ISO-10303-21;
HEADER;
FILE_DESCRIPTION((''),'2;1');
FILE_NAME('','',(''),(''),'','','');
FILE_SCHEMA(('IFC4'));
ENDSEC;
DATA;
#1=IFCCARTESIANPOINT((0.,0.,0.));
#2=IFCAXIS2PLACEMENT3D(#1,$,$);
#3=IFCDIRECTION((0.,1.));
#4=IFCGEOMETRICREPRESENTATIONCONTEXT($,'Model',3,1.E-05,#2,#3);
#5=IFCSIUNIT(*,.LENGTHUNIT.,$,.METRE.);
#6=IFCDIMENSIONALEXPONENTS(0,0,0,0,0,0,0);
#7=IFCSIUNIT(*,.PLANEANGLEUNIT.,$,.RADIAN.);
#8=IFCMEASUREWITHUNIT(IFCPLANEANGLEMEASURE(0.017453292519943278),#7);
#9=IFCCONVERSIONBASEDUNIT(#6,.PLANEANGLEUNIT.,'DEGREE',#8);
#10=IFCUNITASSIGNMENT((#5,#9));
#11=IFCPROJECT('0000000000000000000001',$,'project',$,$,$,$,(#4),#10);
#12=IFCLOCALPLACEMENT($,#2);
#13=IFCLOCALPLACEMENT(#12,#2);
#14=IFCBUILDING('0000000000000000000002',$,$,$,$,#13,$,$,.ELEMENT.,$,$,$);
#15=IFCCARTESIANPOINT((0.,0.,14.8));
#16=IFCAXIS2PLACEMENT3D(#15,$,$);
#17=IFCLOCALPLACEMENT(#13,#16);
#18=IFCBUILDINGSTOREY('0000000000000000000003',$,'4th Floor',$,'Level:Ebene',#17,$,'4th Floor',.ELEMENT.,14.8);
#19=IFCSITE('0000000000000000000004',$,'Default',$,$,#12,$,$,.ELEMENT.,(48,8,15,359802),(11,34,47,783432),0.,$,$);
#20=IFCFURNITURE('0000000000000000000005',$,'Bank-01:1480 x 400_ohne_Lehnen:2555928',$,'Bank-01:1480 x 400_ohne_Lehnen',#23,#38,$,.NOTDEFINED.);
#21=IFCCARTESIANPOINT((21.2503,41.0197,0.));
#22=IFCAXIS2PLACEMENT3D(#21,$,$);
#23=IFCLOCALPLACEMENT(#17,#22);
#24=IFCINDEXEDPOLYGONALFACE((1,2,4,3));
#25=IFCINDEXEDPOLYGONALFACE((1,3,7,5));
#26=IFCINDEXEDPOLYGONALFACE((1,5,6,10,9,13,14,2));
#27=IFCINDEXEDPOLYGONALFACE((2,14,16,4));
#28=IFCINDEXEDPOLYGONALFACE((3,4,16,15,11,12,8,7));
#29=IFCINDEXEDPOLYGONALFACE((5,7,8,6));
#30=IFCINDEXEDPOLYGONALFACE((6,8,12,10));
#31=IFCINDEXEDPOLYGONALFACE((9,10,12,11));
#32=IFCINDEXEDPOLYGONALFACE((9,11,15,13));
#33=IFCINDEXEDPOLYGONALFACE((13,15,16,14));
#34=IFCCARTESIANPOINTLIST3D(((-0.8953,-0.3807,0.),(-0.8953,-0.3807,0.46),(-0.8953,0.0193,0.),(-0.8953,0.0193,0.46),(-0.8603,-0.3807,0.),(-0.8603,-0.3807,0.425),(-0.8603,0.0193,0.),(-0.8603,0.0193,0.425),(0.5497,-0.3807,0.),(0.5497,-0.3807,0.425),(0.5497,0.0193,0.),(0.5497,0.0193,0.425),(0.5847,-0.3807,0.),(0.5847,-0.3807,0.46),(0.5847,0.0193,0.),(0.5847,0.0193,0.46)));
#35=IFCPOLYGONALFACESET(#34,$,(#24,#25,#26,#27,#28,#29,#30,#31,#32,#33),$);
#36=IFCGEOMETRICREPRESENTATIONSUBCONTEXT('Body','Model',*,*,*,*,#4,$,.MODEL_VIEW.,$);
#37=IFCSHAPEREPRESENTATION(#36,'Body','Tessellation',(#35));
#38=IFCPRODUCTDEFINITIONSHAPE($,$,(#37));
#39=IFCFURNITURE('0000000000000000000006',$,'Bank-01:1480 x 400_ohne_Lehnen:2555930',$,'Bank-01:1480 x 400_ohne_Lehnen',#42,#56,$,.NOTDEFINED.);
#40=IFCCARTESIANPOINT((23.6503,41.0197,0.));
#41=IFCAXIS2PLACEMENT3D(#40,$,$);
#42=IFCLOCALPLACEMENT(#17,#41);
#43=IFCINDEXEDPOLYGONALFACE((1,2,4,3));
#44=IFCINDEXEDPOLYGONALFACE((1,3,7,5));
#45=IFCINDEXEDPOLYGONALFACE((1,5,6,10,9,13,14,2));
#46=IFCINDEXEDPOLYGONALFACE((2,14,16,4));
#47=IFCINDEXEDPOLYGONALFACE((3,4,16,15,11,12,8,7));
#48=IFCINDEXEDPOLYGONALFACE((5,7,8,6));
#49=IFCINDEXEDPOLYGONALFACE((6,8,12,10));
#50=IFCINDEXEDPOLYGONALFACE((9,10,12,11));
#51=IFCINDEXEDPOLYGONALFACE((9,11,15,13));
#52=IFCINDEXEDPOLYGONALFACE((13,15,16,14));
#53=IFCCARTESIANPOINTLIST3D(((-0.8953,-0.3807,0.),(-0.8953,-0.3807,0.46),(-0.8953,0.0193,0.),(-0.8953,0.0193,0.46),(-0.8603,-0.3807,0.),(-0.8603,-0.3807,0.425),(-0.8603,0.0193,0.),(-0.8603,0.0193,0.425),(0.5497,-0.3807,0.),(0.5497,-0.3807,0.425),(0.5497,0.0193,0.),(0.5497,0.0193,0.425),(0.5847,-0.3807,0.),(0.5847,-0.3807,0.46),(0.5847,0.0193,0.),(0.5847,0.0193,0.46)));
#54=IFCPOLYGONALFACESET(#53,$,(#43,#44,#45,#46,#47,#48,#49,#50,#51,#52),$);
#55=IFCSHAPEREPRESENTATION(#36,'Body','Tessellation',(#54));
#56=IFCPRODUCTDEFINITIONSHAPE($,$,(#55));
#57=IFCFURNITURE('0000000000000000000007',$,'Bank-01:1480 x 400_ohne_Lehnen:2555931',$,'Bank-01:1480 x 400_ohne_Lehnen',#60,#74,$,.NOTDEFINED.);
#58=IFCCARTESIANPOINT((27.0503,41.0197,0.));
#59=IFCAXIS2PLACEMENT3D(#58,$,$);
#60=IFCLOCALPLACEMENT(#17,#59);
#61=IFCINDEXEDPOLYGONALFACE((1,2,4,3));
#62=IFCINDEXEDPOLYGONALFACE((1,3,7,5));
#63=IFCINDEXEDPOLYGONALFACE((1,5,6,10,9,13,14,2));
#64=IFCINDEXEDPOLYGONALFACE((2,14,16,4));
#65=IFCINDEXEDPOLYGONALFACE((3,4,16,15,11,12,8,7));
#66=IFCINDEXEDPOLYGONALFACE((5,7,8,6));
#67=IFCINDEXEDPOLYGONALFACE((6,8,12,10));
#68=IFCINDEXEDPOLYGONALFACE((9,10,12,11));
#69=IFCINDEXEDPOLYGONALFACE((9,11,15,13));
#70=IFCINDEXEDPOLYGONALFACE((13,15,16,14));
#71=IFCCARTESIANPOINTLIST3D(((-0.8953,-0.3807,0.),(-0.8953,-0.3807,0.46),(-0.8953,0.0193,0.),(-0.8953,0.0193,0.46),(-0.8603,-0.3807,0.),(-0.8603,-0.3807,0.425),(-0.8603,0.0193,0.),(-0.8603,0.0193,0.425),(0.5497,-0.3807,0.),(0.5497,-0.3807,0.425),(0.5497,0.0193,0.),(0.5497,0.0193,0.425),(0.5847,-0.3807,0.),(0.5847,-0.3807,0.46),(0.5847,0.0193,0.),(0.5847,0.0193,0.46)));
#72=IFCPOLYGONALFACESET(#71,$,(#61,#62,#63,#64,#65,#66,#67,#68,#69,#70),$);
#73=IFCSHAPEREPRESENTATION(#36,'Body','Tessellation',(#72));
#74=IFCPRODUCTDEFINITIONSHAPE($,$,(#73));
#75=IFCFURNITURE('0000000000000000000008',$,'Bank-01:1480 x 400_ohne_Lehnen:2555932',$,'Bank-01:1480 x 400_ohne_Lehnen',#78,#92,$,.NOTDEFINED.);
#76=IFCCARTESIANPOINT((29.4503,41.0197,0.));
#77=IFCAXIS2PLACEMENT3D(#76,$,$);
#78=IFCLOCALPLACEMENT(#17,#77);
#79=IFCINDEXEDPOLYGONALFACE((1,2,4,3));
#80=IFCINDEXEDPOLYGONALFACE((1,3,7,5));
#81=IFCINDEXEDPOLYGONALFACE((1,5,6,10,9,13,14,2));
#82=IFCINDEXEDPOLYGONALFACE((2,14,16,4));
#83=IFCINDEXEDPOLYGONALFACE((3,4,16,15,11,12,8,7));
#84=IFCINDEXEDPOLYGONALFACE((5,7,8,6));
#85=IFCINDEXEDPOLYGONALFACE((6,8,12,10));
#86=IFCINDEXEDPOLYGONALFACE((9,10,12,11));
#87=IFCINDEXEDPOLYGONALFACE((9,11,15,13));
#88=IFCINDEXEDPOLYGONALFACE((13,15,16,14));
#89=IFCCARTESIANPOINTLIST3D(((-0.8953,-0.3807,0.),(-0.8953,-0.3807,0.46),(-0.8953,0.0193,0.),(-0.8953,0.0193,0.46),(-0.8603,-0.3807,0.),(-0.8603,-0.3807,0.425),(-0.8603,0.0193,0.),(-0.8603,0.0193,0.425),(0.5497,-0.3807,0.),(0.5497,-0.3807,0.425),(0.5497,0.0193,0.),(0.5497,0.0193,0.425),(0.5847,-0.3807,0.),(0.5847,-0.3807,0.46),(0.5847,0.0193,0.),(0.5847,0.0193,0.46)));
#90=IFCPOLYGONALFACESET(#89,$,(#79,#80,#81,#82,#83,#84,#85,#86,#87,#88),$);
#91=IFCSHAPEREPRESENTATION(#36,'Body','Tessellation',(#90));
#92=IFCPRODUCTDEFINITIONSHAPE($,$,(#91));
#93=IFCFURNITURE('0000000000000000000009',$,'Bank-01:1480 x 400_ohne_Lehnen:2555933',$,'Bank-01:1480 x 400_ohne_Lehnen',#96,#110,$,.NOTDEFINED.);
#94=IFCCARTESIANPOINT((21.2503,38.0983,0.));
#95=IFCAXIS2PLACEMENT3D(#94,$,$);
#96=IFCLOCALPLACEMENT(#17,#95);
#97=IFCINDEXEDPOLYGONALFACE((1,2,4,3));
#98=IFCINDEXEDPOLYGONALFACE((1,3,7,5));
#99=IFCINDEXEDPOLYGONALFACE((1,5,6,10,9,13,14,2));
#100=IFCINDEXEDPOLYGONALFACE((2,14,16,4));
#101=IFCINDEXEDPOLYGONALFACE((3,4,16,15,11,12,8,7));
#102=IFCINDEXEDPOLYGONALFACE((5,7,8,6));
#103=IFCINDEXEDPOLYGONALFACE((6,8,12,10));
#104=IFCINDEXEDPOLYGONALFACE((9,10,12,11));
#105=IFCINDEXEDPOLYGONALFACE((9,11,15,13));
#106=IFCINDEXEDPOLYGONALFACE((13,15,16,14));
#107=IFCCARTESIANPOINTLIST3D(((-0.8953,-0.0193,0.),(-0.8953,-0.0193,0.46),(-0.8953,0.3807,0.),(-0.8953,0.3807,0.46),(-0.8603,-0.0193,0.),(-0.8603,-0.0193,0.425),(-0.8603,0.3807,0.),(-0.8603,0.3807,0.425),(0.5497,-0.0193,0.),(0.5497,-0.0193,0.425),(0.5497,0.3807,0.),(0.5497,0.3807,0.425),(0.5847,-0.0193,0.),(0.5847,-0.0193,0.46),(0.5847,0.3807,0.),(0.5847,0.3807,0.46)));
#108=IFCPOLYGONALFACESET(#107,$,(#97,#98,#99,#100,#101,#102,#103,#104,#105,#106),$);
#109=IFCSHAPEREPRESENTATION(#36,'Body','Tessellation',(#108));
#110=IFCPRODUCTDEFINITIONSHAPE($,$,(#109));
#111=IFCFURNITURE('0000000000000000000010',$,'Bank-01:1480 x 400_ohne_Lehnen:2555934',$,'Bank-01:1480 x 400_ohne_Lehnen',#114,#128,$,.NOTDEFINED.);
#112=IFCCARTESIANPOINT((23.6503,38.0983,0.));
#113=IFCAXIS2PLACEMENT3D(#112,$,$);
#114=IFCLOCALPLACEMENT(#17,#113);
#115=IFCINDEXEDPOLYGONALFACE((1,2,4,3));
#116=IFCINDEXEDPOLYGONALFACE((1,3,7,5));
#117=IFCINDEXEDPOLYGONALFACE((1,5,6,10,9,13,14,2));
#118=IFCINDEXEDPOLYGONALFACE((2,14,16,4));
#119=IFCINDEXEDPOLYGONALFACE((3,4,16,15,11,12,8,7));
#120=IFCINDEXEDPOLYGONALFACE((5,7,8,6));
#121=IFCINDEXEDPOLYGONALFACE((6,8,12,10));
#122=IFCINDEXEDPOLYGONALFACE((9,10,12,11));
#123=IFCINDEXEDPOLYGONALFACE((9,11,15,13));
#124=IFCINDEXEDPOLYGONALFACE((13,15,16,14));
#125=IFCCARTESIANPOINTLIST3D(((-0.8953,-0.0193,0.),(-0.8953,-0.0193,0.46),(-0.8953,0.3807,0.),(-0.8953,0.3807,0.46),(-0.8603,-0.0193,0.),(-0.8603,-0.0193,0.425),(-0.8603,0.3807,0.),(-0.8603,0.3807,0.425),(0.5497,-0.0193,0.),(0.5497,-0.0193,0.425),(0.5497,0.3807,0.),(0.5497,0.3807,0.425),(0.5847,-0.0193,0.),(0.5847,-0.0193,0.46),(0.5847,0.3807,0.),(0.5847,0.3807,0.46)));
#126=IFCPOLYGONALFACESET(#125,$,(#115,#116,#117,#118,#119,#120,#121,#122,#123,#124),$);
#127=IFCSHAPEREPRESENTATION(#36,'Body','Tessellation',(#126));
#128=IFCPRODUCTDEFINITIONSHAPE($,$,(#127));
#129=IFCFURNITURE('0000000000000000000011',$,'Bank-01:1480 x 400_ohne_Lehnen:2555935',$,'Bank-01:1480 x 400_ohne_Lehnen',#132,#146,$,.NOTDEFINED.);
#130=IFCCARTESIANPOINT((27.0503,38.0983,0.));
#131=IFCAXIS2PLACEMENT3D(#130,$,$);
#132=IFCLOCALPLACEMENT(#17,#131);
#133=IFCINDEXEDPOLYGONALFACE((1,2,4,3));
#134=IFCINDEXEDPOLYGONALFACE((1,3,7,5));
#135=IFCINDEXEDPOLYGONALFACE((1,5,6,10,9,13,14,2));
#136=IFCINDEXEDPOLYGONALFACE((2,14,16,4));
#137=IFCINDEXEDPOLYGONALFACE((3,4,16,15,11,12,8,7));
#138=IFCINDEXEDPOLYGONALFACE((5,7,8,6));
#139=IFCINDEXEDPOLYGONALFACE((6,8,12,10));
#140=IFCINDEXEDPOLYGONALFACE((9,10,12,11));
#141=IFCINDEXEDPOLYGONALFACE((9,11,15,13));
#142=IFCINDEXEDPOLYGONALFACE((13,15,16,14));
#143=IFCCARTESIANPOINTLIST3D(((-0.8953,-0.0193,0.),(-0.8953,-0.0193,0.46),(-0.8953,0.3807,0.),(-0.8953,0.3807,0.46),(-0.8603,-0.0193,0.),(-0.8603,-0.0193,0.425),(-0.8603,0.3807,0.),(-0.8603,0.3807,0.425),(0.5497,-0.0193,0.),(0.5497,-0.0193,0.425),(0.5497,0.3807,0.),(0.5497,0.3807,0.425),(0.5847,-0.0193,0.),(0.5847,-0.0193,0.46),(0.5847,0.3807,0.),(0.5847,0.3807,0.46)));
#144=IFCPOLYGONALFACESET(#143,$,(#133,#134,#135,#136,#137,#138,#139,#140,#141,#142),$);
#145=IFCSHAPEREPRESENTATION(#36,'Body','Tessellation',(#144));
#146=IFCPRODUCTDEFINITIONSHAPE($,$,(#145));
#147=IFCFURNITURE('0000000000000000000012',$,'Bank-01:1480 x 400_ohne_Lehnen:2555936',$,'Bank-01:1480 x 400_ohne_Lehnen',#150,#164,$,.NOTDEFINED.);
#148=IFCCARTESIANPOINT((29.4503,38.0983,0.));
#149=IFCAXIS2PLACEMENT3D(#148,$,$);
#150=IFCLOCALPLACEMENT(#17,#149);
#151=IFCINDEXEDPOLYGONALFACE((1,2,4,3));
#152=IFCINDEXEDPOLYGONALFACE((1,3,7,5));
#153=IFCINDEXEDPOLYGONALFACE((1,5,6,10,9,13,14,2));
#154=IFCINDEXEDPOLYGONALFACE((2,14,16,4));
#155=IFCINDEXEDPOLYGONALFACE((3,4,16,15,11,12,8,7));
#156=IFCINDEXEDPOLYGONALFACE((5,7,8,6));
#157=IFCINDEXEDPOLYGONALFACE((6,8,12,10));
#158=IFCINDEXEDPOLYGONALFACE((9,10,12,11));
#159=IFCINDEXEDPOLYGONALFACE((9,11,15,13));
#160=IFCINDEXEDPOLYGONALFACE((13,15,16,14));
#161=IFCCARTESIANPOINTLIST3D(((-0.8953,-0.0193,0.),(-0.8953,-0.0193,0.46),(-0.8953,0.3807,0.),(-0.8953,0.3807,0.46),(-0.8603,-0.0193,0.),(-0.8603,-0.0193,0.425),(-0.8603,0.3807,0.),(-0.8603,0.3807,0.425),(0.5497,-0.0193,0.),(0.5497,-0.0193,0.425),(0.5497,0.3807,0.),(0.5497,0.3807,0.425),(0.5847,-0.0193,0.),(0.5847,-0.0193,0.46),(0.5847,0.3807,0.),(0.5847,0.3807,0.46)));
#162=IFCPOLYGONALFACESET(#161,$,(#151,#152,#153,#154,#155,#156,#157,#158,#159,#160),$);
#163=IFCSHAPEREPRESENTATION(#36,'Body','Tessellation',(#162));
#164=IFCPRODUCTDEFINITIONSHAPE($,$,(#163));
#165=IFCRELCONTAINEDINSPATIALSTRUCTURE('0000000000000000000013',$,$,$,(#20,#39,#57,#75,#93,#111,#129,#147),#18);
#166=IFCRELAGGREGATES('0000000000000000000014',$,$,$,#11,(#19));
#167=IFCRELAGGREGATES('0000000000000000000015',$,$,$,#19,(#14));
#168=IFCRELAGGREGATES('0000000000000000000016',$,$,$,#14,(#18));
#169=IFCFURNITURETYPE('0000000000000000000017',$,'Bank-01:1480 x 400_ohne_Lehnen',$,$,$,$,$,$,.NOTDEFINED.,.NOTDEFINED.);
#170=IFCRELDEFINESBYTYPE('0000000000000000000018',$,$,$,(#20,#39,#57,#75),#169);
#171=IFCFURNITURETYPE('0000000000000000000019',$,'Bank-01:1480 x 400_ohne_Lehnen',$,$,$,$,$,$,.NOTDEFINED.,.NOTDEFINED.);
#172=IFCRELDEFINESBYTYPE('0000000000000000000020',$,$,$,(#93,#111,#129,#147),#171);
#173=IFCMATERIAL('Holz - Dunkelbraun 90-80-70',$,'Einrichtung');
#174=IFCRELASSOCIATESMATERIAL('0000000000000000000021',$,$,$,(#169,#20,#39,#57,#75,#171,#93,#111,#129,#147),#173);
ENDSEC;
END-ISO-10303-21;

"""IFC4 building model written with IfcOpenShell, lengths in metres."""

from ifc_helpers import new_model, entity, si_unit, converted_unit, direction, frame, origin, place, context, subcontext, project, spatial, indexed_curve, outline, extrude, source, transform, mapped, material, type_object, type_shapes, element, save


model = new_model("IFC4")

# Units and contexts
model_context = context("Model", 3, precision=1e-05, world=origin(), true_north=direction((0.0, 1.0)))
body_context = subcontext(model_context, "Body", "Model", "MODEL_VIEW")
ifc_project = project(units=[si_unit("LENGTHUNIT", "METRE"), converted_unit("PLANEANGLEUNIT", "DEGREE", entity("IfcPlaneAngleMeasure", 0.017453292519943278), si_unit("PLANEANGLEUNIT", "RADIAN"), dimensions=[0, 0, 0, 0, 0, 0, 0])], contexts=[model_context])

# Site, building, storey
site_placement = place(None, origin())
site = spatial("IfcSite", under=ifc_project, at=site_placement, Name="Default", CompositionType="ELEMENT", RefLatitude=(48, 8, 15, 359802), RefLongitude=(11, 34, 47, 783432), RefElevation=0.0)
building_placement = place(site_placement, origin())
building = spatial("IfcBuilding", under=site, at=building_placement, CompositionType="ELEMENT")
storey_placement = place(building_placement, frame((0.0, 0.0, 14.8)))
storey = spatial("IfcBuildingStorey", under=building, at=storey_placement, Name="4th Floor", ObjectType="Level:Ebene", LongName="4th Floor", CompositionType="ELEMENT", Elevation=14.8)

# Furniture
ifc_material_1 = material(Name="Holz - Dunkelbraun 90-80-70", Category="Einrichtung")
furniture_type_1 = type_object("IfcFurnitureType", Name="Bank-01:1480 x 400_ohne_Lehnen", AssemblyPlace="NOTDEFINED", PredefinedType="NOTDEFINED", material=ifc_material_1)
shared_shape_1 = source(origin(), body_context, "Body", "SweptSolid", [
    extrude(outline(indexed_curve([(-0.74, -0.2387), (0.74, -0.2387), (0.74, 0.2213), (0.705, 0.2213), (0.705, -0.2038), (-0.705, -0.2038), (-0.705, 0.2213), (-0.74, 0.2213), (-0.74, -0.2387)], self_intersect=False)), frame((-0.1553, -0.3807, 0.2213), z_axis=(0.0, 1.0, 0.0), x_axis=(1.0, 0.0, 0.0)), (0.0, 0.0, 1.0), 0.4),
])
type_shapes(furniture_type_1, [shared_shape_1])
for number, where, name in (
    (1, (21.2503, 41.0197, 0.0), "Bank-01:1480 x 400_ohne_Lehnen:2555928"),
    (2, (23.6503, 41.0197, 0.0), "Bank-01:1480 x 400_ohne_Lehnen:2555930"),
    (3, (27.0503, 41.0197, 0.0), "Bank-01:1480 x 400_ohne_Lehnen:2555931"),
    (4, (29.4503, 41.0197, 0.0), "Bank-01:1480 x 400_ohne_Lehnen:2555932"),
):
    element("IfcFurniture", number, at=place(storey_placement, frame(where)), inside=storey, type_object=furniture_type_1, material=ifc_material_1, Name=name, ObjectType="Bank-01:1480 x 400_ohne_Lehnen", PredefinedType="NOTDEFINED", context=body_context, shape_type="MappedRepresentation", body=[
        mapped(shared_shape_1, transform((0.0, 0.0, 0.0), scale=1.0)),
    ])
furniture_type_2 = type_object("IfcFurnitureType", Name="Bank-01:1480 x 400_ohne_Lehnen", AssemblyPlace="NOTDEFINED", PredefinedType="NOTDEFINED", material=ifc_material_1)
shared_shape_2 = source(origin(), body_context, "Body", "SweptSolid", [
    extrude(outline(indexed_curve([(-0.74, -0.2387), (0.74, -0.2387), (0.74, 0.2213), (0.705, 0.2213), (0.705, -0.2038), (-0.705, -0.2038), (-0.705, 0.2213), (-0.74, 0.2213), (-0.74, -0.2387)], self_intersect=False)), frame((-0.1553, -0.0193, 0.2213), z_axis=(0.0, 1.0, 0.0), x_axis=(1.0, 0.0, 0.0)), (0.0, 0.0, 1.0), 0.4),
])
type_shapes(furniture_type_2, [shared_shape_2])
for number, where, name in (
    (5, (21.2503, 38.0983, 0.0), "Bank-01:1480 x 400_ohne_Lehnen:2555933"),
    (6, (23.6503, 38.0983, 0.0), "Bank-01:1480 x 400_ohne_Lehnen:2555934"),
    (7, (27.0503, 38.0983, 0.0), "Bank-01:1480 x 400_ohne_Lehnen:2555935"),
    (8, (29.4503, 38.0983, 0.0), "Bank-01:1480 x 400_ohne_Lehnen:2555936"),
):
    element("IfcFurniture", number, at=place(storey_placement, frame(where)), inside=storey, type_object=furniture_type_2, material=ifc_material_1, Name=name, ObjectType="Bank-01:1480 x 400_ohne_Lehnen", PredefinedType="NOTDEFINED", context=body_context, shape_type="MappedRepresentation", body=[
        mapped(shared_shape_2, transform((0.0, 0.0, 0.0), scale=1.0)),
    ])

save(model, "model.ifc")
